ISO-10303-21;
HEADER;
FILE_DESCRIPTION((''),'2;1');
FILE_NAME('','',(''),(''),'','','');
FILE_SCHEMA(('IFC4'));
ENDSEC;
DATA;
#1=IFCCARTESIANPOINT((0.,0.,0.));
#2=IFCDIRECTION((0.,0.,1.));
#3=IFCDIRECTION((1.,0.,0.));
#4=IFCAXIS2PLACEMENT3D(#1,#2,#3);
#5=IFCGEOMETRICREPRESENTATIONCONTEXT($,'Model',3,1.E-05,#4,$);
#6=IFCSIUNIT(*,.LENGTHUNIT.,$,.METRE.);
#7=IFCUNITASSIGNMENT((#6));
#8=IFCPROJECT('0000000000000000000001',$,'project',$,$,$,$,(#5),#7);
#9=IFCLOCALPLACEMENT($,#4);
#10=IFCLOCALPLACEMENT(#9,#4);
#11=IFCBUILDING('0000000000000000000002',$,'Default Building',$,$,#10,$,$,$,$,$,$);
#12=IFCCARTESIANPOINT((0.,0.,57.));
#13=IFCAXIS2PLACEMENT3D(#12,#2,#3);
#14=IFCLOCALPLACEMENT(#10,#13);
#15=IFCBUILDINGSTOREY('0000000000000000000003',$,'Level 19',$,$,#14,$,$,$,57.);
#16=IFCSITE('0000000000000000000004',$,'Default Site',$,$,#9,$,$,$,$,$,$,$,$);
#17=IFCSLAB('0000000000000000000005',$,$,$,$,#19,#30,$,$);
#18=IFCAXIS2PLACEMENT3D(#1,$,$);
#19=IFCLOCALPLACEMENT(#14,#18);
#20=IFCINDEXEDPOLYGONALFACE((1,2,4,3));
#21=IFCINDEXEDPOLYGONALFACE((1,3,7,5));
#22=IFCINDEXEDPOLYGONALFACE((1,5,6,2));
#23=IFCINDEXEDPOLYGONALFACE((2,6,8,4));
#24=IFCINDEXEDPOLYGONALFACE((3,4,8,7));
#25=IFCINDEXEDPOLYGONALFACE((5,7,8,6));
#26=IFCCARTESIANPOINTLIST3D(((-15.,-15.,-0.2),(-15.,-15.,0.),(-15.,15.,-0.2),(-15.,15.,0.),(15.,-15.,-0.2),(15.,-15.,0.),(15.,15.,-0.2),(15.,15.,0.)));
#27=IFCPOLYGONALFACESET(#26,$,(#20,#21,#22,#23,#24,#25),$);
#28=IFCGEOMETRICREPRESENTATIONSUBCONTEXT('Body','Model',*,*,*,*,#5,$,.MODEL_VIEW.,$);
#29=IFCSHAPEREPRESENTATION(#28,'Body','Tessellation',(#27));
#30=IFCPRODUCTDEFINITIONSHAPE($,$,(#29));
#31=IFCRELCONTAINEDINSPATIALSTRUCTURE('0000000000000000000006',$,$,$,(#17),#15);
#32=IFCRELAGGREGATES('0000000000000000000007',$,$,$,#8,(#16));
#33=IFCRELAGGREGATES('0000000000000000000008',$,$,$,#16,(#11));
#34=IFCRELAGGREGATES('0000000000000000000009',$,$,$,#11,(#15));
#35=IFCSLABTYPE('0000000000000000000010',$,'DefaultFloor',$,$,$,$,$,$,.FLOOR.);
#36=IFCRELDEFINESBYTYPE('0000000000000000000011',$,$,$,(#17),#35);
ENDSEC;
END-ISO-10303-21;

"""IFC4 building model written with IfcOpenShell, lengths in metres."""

from ifc_helpers import new_model, si_unit, frame, origin_with_axes, place, context, subcontext, project, spatial, polyline, outline, extrude, type_object, element, save


model = new_model("IFC4")

# Units and contexts
model_context = context("Model", 3, precision=1e-05, world=origin_with_axes())
body_context = subcontext(model_context, "Body", "Model", "MODEL_VIEW")
ifc_project = project(units=[si_unit("LENGTHUNIT", "METRE")], contexts=[model_context])

# Site, building, storey
site_placement = place(None, origin_with_axes())
site = spatial("IfcSite", under=ifc_project, at=site_placement, Name="Default Site")
building_placement = place(site_placement, origin_with_axes())
building = spatial("IfcBuilding", under=site, at=building_placement, Name="Default Building")
storey_placement = place(building_placement, frame((0.0, 0.0, 57.0), z_axis=(0.0, 0.0, 1.0), x_axis=(1.0, 0.0, 0.0)))
storey = spatial("IfcBuildingStorey", under=building, at=storey_placement, Name="Level 19", Elevation=57.0)

# Slab
slab_type = type_object("IfcSlabType", Name="DefaultFloor", PredefinedType="FLOOR")
slab_placement = place(storey_placement, frame((0.0, 0.0, -57.0), z_axis=(0.0, 0.0, 1.0), x_axis=(1.0, 0.0, 0.0)))
element("IfcSlab", 1, at=slab_placement, inside=storey, type_object=slab_type, context=body_context, shape_type="SweptSolid", body=[
    extrude(outline(polyline([(-15.0, 15.0), (15.0, 15.0), (15.0, -15.0), (-15.0, -15.0), (-15.0, 15.0)])), frame((0.0, 0.0, 57.0), z_axis=(0.0, 0.0, 1.0), x_axis=(1.0, 0.0, 0.0)), (0.0, 0.0, -1.0), 0.2),
])

save(model, "model.ifc")
